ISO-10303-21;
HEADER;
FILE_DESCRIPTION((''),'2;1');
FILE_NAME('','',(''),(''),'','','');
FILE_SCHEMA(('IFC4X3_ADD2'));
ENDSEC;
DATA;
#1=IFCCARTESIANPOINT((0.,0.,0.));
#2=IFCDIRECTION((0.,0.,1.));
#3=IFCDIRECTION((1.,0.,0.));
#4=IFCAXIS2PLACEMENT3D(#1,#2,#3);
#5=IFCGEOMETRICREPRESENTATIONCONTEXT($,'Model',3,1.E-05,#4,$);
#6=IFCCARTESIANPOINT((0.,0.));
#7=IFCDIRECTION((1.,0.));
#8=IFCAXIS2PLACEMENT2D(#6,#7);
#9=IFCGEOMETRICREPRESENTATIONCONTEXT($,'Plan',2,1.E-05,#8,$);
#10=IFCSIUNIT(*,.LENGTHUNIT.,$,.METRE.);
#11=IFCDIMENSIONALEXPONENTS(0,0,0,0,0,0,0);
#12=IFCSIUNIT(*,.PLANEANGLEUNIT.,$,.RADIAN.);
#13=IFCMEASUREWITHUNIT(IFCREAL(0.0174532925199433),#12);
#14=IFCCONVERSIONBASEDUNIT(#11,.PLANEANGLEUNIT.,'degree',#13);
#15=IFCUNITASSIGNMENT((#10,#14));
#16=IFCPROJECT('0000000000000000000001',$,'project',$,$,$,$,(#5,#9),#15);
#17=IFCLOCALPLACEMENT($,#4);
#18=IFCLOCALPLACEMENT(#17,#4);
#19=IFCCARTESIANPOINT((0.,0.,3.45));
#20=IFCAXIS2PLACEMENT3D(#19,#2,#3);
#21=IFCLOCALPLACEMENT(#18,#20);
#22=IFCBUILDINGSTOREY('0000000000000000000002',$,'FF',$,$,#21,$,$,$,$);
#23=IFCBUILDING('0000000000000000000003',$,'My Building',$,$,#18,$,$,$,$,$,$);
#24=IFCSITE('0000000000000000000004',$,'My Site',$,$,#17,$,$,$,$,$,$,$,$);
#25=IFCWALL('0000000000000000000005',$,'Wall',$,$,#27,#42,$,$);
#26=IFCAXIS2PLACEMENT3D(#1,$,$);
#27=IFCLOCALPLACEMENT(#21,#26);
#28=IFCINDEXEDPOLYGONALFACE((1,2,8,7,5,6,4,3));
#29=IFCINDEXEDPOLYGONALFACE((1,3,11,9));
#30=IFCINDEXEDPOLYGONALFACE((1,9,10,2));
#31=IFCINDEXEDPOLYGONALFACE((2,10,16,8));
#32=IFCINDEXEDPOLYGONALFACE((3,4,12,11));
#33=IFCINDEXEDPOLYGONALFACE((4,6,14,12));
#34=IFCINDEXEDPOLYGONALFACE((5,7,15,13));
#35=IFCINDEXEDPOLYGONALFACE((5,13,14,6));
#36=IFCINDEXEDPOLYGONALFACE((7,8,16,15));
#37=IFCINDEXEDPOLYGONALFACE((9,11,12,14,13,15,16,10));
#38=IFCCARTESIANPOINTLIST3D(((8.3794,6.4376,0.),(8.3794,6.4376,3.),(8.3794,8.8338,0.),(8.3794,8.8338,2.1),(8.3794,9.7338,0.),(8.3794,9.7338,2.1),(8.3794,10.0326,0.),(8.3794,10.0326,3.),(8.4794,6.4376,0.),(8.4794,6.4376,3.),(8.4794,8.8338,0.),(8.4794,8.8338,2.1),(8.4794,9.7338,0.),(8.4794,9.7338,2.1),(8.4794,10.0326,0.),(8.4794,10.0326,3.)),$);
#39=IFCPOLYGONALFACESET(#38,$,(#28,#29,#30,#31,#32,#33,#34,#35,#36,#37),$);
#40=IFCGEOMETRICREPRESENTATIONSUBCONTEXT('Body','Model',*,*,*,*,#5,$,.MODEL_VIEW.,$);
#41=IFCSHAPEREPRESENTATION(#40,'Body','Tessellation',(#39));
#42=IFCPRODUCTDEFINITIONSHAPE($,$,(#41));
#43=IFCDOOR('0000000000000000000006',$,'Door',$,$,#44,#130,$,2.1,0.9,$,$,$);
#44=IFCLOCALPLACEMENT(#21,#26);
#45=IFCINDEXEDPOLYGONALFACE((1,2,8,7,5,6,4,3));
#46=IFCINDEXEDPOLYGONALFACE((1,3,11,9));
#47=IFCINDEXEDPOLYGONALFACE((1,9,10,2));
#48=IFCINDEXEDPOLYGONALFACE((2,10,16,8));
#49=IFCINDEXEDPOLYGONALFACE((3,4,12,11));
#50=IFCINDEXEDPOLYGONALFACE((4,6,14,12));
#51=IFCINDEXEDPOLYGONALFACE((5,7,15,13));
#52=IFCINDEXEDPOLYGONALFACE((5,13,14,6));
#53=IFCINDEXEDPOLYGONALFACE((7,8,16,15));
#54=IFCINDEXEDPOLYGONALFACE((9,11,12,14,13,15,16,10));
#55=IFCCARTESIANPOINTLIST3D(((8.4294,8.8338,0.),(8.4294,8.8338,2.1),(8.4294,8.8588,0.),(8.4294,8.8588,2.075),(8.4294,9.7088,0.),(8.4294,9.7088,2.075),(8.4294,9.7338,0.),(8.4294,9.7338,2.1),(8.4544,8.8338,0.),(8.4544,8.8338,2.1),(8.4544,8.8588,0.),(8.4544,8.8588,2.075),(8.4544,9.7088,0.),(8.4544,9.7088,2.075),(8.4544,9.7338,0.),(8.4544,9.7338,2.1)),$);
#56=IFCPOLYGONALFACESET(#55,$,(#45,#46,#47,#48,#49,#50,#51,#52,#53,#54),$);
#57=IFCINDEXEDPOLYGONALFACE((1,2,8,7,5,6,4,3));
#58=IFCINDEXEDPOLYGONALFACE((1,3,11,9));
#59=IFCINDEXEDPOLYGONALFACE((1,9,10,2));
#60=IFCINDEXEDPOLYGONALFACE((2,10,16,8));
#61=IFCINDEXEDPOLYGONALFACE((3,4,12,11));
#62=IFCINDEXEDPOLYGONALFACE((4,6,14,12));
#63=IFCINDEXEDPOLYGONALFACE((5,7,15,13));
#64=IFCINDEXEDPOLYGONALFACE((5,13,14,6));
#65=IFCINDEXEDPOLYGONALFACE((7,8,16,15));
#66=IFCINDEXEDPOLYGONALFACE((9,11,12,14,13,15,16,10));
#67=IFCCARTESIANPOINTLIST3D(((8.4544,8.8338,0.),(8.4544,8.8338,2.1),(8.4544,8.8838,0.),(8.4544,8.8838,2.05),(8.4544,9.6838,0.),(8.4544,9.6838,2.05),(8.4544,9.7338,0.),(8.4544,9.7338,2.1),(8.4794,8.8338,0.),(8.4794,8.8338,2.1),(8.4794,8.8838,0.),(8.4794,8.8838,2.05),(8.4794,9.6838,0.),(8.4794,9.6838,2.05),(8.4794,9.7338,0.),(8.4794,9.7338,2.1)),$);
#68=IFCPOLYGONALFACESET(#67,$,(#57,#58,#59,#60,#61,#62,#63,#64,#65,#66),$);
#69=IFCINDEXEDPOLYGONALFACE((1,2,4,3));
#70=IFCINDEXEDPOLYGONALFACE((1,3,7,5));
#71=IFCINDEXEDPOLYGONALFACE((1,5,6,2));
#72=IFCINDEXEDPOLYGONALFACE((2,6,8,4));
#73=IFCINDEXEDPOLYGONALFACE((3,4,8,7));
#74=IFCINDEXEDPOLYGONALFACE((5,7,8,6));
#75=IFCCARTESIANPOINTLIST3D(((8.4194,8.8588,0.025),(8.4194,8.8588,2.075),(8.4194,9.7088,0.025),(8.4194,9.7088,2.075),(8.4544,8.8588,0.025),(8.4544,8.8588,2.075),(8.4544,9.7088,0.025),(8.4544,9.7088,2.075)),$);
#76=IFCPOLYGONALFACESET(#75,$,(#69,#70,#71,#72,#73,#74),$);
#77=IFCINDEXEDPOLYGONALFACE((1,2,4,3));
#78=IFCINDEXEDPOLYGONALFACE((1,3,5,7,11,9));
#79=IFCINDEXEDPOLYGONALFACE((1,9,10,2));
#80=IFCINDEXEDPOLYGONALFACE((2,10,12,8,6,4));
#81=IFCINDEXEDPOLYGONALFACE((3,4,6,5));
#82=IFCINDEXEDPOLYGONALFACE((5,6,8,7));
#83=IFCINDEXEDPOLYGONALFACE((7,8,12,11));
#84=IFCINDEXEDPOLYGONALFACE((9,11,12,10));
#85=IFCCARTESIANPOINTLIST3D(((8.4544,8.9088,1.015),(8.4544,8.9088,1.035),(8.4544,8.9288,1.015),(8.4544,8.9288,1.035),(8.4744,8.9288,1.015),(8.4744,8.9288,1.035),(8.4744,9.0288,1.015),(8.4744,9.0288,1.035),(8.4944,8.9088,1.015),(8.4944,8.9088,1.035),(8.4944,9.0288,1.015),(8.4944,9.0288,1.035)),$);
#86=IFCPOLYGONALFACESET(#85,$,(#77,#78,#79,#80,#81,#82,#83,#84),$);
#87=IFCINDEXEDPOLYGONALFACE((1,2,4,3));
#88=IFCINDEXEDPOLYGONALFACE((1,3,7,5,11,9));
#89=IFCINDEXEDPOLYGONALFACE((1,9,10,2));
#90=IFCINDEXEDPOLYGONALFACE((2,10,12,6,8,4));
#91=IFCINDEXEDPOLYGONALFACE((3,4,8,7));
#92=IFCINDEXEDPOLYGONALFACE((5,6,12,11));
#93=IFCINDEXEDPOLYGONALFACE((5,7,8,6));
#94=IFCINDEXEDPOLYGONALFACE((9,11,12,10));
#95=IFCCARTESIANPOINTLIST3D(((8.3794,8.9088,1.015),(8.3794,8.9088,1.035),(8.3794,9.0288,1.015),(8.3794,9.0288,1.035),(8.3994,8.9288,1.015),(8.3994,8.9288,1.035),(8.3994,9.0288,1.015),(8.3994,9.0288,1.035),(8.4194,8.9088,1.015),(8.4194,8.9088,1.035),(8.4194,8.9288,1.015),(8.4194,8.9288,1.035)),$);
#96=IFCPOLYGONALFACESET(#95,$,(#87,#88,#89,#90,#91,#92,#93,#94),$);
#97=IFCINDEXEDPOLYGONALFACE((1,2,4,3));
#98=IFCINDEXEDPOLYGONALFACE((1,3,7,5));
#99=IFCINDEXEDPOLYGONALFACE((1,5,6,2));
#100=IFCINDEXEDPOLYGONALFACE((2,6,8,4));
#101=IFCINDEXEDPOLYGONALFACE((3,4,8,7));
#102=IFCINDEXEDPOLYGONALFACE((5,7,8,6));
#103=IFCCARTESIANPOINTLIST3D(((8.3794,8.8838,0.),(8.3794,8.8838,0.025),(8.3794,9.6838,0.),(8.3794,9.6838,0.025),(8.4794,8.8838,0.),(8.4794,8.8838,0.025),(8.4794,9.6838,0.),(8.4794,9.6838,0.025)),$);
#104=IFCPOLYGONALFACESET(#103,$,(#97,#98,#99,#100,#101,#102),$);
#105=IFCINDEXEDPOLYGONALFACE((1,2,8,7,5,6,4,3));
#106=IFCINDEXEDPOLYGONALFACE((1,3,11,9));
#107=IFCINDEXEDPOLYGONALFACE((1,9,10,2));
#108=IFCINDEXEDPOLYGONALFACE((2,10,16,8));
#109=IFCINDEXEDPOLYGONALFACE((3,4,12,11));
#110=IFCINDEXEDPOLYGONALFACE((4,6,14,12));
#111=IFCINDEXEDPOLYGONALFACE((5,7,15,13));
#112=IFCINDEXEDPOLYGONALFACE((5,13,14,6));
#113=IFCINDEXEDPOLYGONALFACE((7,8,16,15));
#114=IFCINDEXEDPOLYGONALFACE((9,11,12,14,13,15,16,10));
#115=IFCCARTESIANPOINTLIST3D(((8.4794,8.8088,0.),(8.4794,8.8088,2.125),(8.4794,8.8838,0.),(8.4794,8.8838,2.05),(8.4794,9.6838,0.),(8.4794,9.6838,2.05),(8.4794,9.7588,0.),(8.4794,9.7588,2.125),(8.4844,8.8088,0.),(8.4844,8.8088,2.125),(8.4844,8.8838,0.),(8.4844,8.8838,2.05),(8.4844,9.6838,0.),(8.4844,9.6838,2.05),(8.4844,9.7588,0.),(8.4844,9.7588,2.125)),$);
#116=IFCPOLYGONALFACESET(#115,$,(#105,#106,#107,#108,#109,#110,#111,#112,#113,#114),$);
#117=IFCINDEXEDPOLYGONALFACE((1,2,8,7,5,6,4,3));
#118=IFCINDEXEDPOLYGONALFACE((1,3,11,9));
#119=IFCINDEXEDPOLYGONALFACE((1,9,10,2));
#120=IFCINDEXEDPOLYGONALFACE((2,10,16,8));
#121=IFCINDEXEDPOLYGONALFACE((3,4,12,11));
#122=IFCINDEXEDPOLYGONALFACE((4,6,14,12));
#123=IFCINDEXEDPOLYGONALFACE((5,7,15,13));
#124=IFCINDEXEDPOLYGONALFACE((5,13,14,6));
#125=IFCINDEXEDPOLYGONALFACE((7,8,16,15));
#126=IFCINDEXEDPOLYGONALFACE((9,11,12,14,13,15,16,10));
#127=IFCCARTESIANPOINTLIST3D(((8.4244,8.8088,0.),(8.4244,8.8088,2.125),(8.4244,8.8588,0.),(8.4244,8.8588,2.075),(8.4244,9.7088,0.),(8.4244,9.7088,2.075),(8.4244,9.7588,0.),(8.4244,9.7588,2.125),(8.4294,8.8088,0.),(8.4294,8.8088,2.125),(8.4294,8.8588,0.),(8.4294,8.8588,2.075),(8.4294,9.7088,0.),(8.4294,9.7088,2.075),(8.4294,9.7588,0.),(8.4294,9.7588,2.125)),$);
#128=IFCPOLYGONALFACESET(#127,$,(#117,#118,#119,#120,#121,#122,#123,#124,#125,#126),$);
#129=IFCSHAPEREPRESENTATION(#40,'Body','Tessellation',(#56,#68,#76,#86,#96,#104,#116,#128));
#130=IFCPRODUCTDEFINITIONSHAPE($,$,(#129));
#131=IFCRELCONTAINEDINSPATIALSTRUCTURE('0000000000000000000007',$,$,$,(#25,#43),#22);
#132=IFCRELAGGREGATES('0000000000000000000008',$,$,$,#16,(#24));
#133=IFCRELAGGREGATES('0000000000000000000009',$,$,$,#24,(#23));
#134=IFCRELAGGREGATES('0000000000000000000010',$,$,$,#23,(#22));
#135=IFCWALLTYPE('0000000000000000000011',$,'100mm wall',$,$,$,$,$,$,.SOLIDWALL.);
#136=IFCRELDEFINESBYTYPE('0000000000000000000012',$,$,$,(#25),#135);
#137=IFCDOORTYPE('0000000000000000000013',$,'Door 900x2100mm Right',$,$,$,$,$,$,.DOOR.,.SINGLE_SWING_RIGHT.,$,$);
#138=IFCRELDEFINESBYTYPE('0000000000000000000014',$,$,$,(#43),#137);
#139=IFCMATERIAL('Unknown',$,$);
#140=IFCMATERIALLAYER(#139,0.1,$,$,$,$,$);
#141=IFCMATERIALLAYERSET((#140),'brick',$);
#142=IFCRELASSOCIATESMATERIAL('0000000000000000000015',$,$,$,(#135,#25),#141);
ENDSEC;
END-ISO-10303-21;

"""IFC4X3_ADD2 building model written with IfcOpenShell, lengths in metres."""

from ifc_helpers import new_model, entity, si_unit, converted_unit, frame, origin_with_axes, origin_2d_with_axis, place, context, subcontext, project, spatial, line, indexed_curve, outline, extrude, shape, source, transform, mapped, material, layer, layer_set, layer_usage, type_object, type_shapes, element, fill, save


model = new_model("IFC4X3_ADD2")

# Units and contexts
model_context = context("Model", 3, precision=1e-05, world=origin_with_axes())
plan_context = context("Plan", 2, precision=1e-05, world=origin_2d_with_axis())
body_context_1 = subcontext(model_context, "Body", "Model", "MODEL_VIEW")
body_context_2 = subcontext(plan_context, "Body", "Plan", "PLAN_VIEW")
ifc_project = project(units=[si_unit("LENGTHUNIT", "METRE"), converted_unit("PLANEANGLEUNIT", "degree", entity("IfcReal", 0.0174532925199433), si_unit("PLANEANGLEUNIT", "RADIAN"), dimensions=[0, 0, 0, 0, 0, 0, 0])], contexts=[model_context, plan_context])

# Site, building, storey
site_placement = place(None, origin_with_axes())
site = spatial("IfcSite", under=ifc_project, at=site_placement, Name="My Site")
building_placement = place(site_placement, origin_with_axes())
building = spatial("IfcBuilding", under=site, at=building_placement, Name="My Building")
storey_placement = place(building_placement, frame((0.0, 0.0, 3.45), z_axis=(0.0, 0.0, 1.0), x_axis=(1.0, 0.0, 0.0)))
storey = spatial("IfcBuildingStorey", under=building, at=storey_placement, Name="FF")

# Shared definitions
ifc_material = material(Name="Unknown")

# Wall, opening, door
ifc_layer_1 = layer(ifc_material, 0.1)
ifc_layer_set_1 = layer_set([ifc_layer_1], Name="brick")
ifc_layer_usage_1 = layer_usage(ifc_layer_set_1, "AXIS2", "POSITIVE", 0.0)
wall_type_1 = type_object("IfcWallType", Name="100mm wall", PredefinedType="SOLIDWALL", material=ifc_layer_set_1)
wall_1_placement = place(storey_placement, frame((8.4794, 6.4376, 0.0), z_axis=(0.0, 0.0, 1.0), x_axis=(0.0, 1.0, 0.0)))
wall_1 = element("IfcWall", 1, at=wall_1_placement, inside=storey, type_object=wall_type_1, material=ifc_layer_usage_1, Name="Wall", context=body_context_1, shape_type="SweptSolid", body=[
    extrude(outline(indexed_curve([(0.0, 0.0), (0.0, 0.1), (3.595, 0.1), (3.595, 0.0), (0.0, 0.0)], self_intersect=False)), origin_with_axes(), (0.0, 0.0, 1.0), 3.0),
])
shared_shape_1 = source(origin_with_axes(), body_context_1, "Body", "SolidModel", [
    extrude(outline(indexed_curve([(0.0, 0.0), (0.9, 0.0), (0.9, 2.1), (0.0, 2.1)], segments=[line(1, 2, 3, 4, 1)])), frame((0.0, -0.6, 0.0), z_axis=(0.0, -1.0, 0.0), x_axis=(1.0, 0.0, 0.0)), (0.0, 0.0, -1.0), 1.2),
])
opening_1_placement = place(wall_1_placement, frame((2.3963, 0.0, 0.0), z_axis=(0.0, 0.0, 1.0), x_axis=(1.0, 0.0, 0.0)))
opening_1 = element("IfcOpeningElement", 2, at=opening_1_placement, cuts=wall_1, PredefinedType="OPENING", context=body_context_1, shape_type="MappedRepresentation", body=[
    mapped(shared_shape_1, transform((0.0, 0.0, 0.0), x_axis=(1.0, 0.0, 0.0), y_axis=(0.0, 1.0, 0.0), z_axis=(0.0, 0.0, 1.0), scale=1.0)),
])
door_type_1 = type_object("IfcDoorType", Name="Door 900x2100mm Right", OperationType="SINGLE_SWING_RIGHT", PredefinedType="DOOR")
shared_shape_2 = source(origin_with_axes(), body_context_1, "Body", "SweptSolid", [
    extrude(outline(indexed_curve([(0.0, 0.0), (0.0, 2.1), (0.9, 2.1), (0.9, 0.0), (0.875, 0.0), (0.875, 2.075), (0.025, 2.075), (0.025, 0.0)], segments=[line(1, 2, 3, 4, 5, 6, 7, 8, 1)])), frame((0.0, 0.025, 0.0), z_axis=(0.0, -1.0, 0.0), x_axis=(1.0, 0.0, 0.0)), (0.0, 0.0, -1.0), 0.025),
    extrude(outline(indexed_curve([(0.0, 0.0), (0.0, 2.1), (0.9, 2.1), (0.9, 0.0), (0.85, 0.0), (0.85, 2.05), (0.05, 2.05), (0.05, 0.0)], segments=[line(1, 2, 3, 4, 5, 6, 7, 8, 1)])), frame((0.0, 0.0, 0.0), z_axis=(0.0, -1.0, 0.0), x_axis=(1.0, 0.0, 0.0)), (0.0, 0.0, -1.0), 0.025),
    extrude(outline(indexed_curve([(0.0, 0.0), (0.85, 0.0), (0.85, 0.035), (0.0, 0.035)], segments=[line(1, 2, 3, 4, 1)])), frame((0.025, 0.025, 0.025), z_axis=(0.0, 0.0, 1.0), x_axis=(1.0, 0.0, 0.0)), (0.0, 0.0, 1.0), 2.05),
    extrude(outline(indexed_curve([(0.0, 0.0), (0.0, -0.04), (0.12, -0.04), (0.12, -0.02), (0.02, -0.02), (0.02, 0.0)], segments=[line(1, 2, 3, 4, 5, 6, 1)])), frame((0.075, 0.025, 1.015), z_axis=(0.0, 0.0, 1.0), x_axis=(1.0, 0.0, 0.0)), (0.0, 0.0, 1.0), 0.02),
    extrude(outline(indexed_curve([(0.0, 0.0), (0.0, 0.04), (0.12, 0.04), (0.12, 0.02), (0.02, 0.02), (0.02, 0.0)], segments=[line(1, 2, 3, 4, 5, 6, 1)])), frame((0.075, 0.06, 1.015), z_axis=(0.0, 0.0, 1.0), x_axis=(1.0, 0.0, 0.0)), (0.0, 0.0, 1.0), 0.02),
    extrude(outline(indexed_curve([(0.0, 0.0), (0.8, 0.0), (0.8, 0.1), (0.0, 0.1)], segments=[line(1, 2, 3, 4, 1)])), frame((0.05, 0.0, 0.0), z_axis=(0.0, 0.0, 1.0), x_axis=(1.0, 0.0, 0.0)), (0.0, 0.0, 1.0), 0.025),
    extrude(outline(indexed_curve([(0.0, 0.0), (0.0, 2.125), (0.95, 2.125), (0.95, 0.0), (0.875, 0.0), (0.875, 2.05), (0.075, 2.05), (0.075, 0.0)], segments=[line(1, 2, 3, 4, 5, 6, 7, 8, 1)])), frame((-0.025, -0.005, 0.0), z_axis=(0.0, -1.0, 0.0), x_axis=(1.0, 0.0, 0.0)), (0.0, 0.0, -1.0), 0.005),
    extrude(outline(indexed_curve([(0.0, 0.0), (0.0, 2.125), (0.95, 2.125), (0.95, 0.0), (0.9, 0.0), (0.9, 2.075), (0.05, 2.075), (0.05, 0.0)], segments=[line(1, 2, 3, 4, 5, 6, 7, 8, 1)])), frame((-0.025, 0.05, 0.0), z_axis=(0.0, -1.0, 0.0), x_axis=(1.0, 0.0, 0.0)), (0.0, 0.0, -1.0), 0.005),
])
shared_shape_3 = source(origin_with_axes(), body_context_2, "Body", "Curve2D", [
    entity("IfcIndexedPolyCurve", entity("IfcCartesianPointList2D", [[0.0, 0.0], [0.0, 0.05], [0.025, 0.05], [0.025, 0.025], [0.05, 0.025], [0.05, 0.0]]), [entity("IfcLineIndex", [1, 2, 3, 4, 5, 6, 1])]),
    entity("IfcIndexedPolyCurve", entity("IfcCartesianPointList2D", [[0.9, 0.0], [0.9, 0.05], [0.875, 0.05], [0.875, 0.025], [0.85, 0.025], [0.85, 0.0]]), [entity("IfcLineIndex", [1, 2, 3, 4, 5, 6, 1])]),
    entity("IfcTrimmedCurve", entity("IfcEllipse", entity("IfcAxis2Placement2D", entity("IfcCartesianPoint", [0.84, 0.05]), entity("IfcDirection", [1.0, 0.0])), 0.815, 0.85), [entity("IfcCartesianPoint", [0.84, 0.9])], [entity("IfcCartesianPoint", [0.025, 0.05])], True, "CARTESIAN"),
    entity("IfcIndexedPolyCurve", entity("IfcCartesianPointList2D", [[0.875, 0.05], [0.84, 0.05], [0.84, 0.9], [0.875, 0.9]]), [entity("IfcLineIndex", [1, 2, 3, 4, 1])]),
])
type_shapes(door_type_1, [shared_shape_2, shared_shape_3])
door_1_placement = place(opening_1_placement, origin_with_axes())
door_1 = element("IfcDoor", 3, at=door_1_placement, inside=storey, type_object=door_type_1, Name="Door", OverallHeight=2.1, OverallWidth=0.9, shapes=[
    shape(body_context_1, "Body", "MappedRepresentation", [mapped(shared_shape_2, transform((0.0, 0.0, 0.0), x_axis=(1.0, 0.0, 0.0), y_axis=(0.0, 1.0, 0.0), z_axis=(0.0, 0.0, 1.0), scale=1.0))]),
    shape(body_context_2, "Body", "MappedRepresentation", [mapped(shared_shape_3, transform((0.0, 0.0, 0.0), x_axis=(1.0, 0.0, 0.0), y_axis=(0.0, 1.0, 0.0), z_axis=(0.0, 0.0, 1.0), scale=1.0))]),
])
fill(opening_1, door_1)

save(model, "model.ifc")
